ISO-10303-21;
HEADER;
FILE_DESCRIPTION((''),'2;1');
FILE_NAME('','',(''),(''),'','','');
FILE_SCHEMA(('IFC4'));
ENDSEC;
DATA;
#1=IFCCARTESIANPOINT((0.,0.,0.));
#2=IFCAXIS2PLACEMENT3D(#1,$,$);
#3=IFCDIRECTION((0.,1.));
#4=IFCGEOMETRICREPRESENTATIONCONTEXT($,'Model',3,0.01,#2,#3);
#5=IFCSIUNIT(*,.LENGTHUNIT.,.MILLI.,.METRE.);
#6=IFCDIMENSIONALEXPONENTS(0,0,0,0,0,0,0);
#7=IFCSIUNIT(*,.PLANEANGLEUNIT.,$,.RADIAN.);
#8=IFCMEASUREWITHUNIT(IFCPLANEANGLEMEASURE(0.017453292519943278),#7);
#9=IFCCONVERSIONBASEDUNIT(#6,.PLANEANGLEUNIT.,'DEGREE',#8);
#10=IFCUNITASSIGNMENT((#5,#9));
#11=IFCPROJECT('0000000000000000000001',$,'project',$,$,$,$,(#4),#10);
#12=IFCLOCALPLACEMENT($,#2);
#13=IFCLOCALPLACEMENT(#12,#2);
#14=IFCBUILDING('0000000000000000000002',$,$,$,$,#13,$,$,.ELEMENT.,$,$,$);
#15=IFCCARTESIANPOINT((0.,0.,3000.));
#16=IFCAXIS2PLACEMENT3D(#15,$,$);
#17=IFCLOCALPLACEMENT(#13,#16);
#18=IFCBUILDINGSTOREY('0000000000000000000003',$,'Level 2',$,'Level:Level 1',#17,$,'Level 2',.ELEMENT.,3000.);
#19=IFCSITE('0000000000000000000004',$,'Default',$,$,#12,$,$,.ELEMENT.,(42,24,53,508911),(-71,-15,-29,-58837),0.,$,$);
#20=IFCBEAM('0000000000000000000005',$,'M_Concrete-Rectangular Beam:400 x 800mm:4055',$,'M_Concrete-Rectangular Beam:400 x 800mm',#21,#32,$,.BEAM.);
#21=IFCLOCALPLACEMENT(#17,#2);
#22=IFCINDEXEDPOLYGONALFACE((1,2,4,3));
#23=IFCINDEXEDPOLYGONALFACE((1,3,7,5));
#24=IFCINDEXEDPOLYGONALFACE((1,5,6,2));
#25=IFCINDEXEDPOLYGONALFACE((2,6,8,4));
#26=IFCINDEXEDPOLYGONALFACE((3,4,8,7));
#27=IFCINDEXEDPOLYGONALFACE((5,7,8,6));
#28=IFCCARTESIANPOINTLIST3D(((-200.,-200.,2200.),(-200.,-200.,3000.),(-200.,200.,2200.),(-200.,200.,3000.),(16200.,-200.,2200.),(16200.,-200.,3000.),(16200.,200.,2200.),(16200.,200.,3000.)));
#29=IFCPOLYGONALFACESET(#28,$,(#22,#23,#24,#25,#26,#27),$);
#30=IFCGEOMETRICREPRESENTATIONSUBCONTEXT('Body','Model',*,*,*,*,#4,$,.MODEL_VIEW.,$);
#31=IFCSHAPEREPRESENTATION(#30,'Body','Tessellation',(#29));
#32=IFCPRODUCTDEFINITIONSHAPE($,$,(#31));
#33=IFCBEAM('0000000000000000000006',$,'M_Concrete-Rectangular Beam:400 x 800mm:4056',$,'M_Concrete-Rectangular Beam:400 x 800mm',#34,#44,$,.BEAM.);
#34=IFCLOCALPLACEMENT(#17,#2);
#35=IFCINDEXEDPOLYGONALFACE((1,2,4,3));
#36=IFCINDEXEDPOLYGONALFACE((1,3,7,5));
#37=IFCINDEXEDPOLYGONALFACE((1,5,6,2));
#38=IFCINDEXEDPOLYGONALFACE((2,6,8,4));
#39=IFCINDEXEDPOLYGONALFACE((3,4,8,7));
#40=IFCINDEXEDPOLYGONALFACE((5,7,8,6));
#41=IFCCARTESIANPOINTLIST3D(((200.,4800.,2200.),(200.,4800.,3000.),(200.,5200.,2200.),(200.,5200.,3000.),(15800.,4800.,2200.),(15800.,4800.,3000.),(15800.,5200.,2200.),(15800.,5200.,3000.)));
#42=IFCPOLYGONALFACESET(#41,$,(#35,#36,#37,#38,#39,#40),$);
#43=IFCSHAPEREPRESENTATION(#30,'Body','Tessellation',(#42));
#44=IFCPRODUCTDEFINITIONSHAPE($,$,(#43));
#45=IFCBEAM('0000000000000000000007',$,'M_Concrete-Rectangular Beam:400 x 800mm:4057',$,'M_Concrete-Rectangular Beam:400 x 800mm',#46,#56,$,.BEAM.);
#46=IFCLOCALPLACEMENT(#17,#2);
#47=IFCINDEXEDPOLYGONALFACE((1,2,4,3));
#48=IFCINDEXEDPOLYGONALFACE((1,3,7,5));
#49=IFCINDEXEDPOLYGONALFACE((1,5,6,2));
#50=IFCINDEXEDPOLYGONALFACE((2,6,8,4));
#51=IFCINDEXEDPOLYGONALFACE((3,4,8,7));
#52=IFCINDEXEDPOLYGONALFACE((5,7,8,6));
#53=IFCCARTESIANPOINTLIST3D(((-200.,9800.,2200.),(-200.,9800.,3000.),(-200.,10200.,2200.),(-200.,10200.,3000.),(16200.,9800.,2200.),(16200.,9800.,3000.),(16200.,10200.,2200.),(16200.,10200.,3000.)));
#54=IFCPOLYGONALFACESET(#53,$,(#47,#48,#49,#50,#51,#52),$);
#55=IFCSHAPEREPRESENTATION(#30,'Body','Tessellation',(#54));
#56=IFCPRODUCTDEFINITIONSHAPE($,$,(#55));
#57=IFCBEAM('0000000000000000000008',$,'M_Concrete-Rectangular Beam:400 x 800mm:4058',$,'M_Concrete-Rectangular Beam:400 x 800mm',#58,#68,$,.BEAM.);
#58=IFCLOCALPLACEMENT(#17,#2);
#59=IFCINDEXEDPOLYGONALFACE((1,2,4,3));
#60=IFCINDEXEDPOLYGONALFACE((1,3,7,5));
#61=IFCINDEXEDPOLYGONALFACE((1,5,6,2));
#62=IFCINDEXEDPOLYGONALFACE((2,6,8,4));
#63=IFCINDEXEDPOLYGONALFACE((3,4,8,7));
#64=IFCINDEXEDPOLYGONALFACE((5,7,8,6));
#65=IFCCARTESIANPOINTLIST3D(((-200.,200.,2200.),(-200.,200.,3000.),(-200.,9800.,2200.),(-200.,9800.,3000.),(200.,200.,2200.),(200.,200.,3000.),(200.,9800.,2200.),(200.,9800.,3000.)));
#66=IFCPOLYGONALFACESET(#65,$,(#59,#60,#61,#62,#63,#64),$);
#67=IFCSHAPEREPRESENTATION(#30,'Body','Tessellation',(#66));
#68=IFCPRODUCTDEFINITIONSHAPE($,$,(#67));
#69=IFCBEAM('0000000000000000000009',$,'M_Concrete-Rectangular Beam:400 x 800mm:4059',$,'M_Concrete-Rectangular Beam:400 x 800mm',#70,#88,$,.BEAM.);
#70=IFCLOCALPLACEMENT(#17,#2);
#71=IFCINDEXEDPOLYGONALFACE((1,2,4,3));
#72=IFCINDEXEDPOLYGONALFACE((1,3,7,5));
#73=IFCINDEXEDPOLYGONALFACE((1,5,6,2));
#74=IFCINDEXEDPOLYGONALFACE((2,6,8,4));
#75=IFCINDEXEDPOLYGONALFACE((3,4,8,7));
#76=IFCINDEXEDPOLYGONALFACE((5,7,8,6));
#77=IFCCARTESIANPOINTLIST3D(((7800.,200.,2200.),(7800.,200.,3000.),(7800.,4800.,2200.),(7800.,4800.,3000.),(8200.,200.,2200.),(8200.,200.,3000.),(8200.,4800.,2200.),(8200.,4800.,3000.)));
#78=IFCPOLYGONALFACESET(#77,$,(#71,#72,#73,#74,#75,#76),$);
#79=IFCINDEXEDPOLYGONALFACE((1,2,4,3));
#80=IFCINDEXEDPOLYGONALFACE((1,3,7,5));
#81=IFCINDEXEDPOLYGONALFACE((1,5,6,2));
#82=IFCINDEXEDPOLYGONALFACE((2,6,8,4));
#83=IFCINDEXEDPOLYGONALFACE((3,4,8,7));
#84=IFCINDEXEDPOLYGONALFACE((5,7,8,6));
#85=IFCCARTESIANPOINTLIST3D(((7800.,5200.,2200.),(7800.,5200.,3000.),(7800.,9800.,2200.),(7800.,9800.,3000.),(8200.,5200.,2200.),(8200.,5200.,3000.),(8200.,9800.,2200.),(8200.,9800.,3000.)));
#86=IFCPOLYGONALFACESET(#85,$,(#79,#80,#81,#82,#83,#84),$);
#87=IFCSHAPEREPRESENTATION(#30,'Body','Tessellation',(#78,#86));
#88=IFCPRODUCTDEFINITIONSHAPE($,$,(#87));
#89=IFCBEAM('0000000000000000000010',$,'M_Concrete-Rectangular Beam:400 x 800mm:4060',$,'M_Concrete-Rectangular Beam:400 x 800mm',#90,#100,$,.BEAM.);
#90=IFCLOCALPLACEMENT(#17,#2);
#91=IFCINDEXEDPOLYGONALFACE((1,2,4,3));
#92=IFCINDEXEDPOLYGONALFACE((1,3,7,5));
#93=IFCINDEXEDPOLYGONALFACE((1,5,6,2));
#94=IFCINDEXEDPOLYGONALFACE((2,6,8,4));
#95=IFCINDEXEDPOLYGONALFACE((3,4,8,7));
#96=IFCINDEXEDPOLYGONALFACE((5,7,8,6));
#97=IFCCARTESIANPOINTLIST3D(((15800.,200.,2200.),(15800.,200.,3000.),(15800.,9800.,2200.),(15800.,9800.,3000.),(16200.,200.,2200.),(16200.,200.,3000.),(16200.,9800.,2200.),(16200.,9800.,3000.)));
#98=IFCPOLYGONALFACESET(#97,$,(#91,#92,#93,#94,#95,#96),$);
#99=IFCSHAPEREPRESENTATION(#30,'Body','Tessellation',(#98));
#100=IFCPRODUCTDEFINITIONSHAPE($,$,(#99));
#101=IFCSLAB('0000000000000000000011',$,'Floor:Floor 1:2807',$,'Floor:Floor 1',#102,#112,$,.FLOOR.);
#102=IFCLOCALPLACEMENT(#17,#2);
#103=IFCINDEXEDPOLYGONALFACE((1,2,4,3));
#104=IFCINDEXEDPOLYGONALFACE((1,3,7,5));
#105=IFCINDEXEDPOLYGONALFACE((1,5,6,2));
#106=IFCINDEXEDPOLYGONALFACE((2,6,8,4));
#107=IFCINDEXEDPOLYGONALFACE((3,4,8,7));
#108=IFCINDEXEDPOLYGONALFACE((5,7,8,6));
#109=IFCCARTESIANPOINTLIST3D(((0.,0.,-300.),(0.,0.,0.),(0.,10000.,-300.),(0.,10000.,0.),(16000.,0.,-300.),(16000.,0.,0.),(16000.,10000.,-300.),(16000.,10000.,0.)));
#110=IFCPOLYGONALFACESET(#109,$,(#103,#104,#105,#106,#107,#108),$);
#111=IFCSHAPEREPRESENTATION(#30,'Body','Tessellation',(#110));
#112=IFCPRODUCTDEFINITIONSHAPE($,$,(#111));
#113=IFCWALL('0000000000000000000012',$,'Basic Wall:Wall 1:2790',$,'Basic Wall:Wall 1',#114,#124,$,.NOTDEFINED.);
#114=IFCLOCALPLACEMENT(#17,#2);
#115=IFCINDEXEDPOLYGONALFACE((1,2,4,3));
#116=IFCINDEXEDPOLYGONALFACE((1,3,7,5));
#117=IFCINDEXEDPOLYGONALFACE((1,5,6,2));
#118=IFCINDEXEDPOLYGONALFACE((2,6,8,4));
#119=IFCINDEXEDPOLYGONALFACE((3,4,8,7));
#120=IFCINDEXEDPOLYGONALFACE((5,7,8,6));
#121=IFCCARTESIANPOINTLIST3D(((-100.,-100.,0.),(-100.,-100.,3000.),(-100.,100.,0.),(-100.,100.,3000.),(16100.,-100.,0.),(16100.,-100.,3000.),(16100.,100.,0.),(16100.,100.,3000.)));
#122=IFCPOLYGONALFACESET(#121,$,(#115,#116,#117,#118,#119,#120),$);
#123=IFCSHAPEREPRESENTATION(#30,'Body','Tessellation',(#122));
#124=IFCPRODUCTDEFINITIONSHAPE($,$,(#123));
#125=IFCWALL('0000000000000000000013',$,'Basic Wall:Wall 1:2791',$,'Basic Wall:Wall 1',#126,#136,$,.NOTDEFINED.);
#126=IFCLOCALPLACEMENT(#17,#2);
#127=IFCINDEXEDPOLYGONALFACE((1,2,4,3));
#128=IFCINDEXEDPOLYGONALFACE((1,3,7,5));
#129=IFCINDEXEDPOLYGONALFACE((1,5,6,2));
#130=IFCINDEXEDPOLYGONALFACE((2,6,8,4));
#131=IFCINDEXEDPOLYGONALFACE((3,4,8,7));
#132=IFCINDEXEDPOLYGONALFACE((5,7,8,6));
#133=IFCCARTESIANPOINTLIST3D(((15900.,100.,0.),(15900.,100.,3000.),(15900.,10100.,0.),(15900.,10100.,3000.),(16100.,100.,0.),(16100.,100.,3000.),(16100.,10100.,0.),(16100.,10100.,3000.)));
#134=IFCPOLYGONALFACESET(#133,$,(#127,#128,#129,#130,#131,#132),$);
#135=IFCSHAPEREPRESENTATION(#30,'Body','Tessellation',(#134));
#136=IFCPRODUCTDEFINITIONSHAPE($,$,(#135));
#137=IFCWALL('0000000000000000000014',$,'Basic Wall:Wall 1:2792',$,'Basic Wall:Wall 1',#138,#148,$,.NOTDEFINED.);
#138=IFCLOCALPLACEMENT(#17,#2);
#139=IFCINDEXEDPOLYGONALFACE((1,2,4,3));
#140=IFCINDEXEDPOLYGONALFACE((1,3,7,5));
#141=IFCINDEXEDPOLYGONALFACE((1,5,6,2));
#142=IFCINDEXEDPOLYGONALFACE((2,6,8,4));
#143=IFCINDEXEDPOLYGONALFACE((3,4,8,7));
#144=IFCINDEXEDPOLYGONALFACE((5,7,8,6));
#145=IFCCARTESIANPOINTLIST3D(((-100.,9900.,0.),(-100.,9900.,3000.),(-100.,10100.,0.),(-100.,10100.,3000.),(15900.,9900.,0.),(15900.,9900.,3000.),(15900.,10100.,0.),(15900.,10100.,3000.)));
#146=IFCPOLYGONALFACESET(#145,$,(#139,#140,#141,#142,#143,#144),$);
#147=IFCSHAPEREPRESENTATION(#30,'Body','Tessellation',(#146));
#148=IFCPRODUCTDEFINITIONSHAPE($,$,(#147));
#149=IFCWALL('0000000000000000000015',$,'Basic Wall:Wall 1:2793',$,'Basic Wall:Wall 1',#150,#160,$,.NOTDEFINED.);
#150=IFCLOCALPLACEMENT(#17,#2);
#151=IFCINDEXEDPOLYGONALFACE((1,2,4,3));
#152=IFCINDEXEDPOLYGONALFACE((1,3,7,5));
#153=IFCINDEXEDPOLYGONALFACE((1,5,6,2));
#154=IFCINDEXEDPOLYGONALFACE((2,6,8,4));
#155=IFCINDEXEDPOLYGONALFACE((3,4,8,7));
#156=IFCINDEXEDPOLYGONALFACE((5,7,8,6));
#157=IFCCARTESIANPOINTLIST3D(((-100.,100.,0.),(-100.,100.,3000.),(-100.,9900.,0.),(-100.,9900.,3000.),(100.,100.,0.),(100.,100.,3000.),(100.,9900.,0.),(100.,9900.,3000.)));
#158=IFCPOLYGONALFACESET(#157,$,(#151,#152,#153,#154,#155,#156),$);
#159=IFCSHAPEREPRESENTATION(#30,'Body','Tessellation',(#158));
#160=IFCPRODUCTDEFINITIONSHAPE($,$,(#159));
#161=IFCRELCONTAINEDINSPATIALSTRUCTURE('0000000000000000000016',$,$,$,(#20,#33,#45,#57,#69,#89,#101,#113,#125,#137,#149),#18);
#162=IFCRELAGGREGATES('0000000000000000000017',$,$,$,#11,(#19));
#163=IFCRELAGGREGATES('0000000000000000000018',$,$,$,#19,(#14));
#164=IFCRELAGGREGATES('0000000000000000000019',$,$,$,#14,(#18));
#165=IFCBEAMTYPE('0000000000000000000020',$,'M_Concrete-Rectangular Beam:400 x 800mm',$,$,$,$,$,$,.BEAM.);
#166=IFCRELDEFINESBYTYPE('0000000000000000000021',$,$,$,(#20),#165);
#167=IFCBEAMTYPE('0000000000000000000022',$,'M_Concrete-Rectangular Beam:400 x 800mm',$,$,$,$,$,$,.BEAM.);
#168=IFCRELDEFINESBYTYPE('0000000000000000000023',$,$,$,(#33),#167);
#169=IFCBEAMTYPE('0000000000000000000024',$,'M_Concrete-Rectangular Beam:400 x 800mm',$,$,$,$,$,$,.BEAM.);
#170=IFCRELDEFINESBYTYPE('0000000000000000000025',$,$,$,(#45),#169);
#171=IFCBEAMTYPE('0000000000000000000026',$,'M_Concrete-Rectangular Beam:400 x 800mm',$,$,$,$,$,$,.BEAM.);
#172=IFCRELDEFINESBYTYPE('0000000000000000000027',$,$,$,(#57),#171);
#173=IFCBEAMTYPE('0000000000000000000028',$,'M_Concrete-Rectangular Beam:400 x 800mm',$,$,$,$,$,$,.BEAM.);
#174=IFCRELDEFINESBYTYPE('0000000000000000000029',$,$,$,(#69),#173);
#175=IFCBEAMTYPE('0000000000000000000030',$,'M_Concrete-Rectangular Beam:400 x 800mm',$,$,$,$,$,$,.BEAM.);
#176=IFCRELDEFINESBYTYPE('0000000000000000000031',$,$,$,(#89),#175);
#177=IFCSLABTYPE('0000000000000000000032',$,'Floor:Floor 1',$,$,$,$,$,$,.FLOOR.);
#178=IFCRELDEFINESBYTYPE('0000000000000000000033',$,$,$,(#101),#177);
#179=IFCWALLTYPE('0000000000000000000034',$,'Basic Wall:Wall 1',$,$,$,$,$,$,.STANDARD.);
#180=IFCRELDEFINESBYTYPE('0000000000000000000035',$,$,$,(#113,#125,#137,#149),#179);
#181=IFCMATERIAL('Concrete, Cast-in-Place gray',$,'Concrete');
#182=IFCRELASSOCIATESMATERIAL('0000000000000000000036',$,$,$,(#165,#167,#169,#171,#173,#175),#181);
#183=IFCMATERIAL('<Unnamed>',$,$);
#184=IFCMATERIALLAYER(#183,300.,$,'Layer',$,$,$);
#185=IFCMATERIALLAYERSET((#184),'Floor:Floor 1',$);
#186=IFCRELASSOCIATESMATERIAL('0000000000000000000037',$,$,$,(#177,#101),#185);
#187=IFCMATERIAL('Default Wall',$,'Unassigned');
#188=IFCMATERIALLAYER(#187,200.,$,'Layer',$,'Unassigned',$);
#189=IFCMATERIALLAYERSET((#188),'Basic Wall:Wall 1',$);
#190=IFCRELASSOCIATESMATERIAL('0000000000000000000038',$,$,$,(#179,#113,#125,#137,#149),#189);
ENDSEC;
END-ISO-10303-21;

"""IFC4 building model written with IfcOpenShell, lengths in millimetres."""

from ifc_helpers import new_model, entity, si_unit, converted_unit, direction, frame, frame_2d, origin, origin_2d_with_axis, place, context, subcontext, project, spatial, rectangle, extrude, source, transform, mapped, material, layer, layer_set, layer_usage, material_profile, profile_set, type_object, type_shapes, element, save


model = new_model("IFC4")

# Units and contexts
model_context = context("Model", 3, precision=0.01, world=origin(), true_north=direction((0.0, 1.0)))
body_context = subcontext(model_context, "Body", "Model", "MODEL_VIEW")
ifc_project = project(units=[si_unit("LENGTHUNIT", "METRE", prefix="MILLI"), converted_unit("PLANEANGLEUNIT", "DEGREE", entity("IfcPlaneAngleMeasure", 0.017453292519943278), si_unit("PLANEANGLEUNIT", "RADIAN"), dimensions=[0, 0, 0, 0, 0, 0, 0])], contexts=[model_context])

# Site, building, storey
site_placement = place(None, origin())
site = spatial("IfcSite", under=ifc_project, at=site_placement, Name="Default", CompositionType="ELEMENT", RefLatitude=(42, 24, 53, 508911), RefLongitude=(-71, -15, -29, -58837), RefElevation=0.0)
building_placement = place(site_placement, origin())
building = spatial("IfcBuilding", under=site, at=building_placement, CompositionType="ELEMENT")
storey_placement = place(building_placement, frame((0.0, 0.0, 3000.0)))
storey = spatial("IfcBuildingStorey", under=building, at=storey_placement, Name="Level 2", ObjectType="Level:Level 1", LongName="Level 2", CompositionType="ELEMENT", Elevation=3000.0)

# Beams
ifc_material_1 = material(Name="Concrete, Cast-in-Place gray", Category="Concrete")
ifc_material_profile = material_profile(ifc_material_1, rectangle(XDim=800.0, YDim=400.0, at=origin_2d_with_axis()), Name="400 x 800mm")
ifc_profile_set = profile_set([ifc_material_profile], Name="400 x 800mm")
beam_type_1 = type_object("IfcBeamType", Name="M_Concrete-Rectangular Beam:400 x 800mm", PredefinedType="BEAM", material=ifc_profile_set)
shared_shape_1 = source(origin(), body_context, "Body", "SweptSolid", [
    extrude(rectangle(XDim=800.0, YDim=400.0, at=origin_2d_with_axis()), frame((-200.0, 0.0, 5600.0), z_axis=(1.0, 0.0, 0.0), x_axis=(0.0, 0.0, -1.0)), (0.0, 0.0, 1.0), 16400.0),
])
type_shapes(beam_type_1, [shared_shape_1])
beam_1_placement = place(storey_placement, frame((0.0, 0.0, -3000.0)))
element("IfcBeam", 1, at=beam_1_placement, inside=storey, type_object=beam_type_1, Name="M_Concrete-Rectangular Beam:400 x 800mm:4055", ObjectType="M_Concrete-Rectangular Beam:400 x 800mm", PredefinedType="BEAM", context=body_context, shape_type="MappedRepresentation", body=[
    mapped(shared_shape_1, transform((0.0, 0.0, 0.0), scale=1.0)),
])
beam_type_2 = type_object("IfcBeamType", Name="M_Concrete-Rectangular Beam:400 x 800mm", PredefinedType="BEAM", material=ifc_profile_set)
shared_shape_2 = source(origin(), body_context, "Body", "SweptSolid", [
    extrude(rectangle(XDim=800.0, YDim=400.0, at=frame_2d((0.0, 0.0), x_axis=(1.0, 0.0))), frame((200.0, 5000.0, 5600.0), z_axis=(1.0, 0.0, 0.0), x_axis=(0.0, 0.0, -1.0)), (0.0, 0.0, 1.0), 15600.0),
])
type_shapes(beam_type_2, [shared_shape_2])
beam_2_placement = place(storey_placement, frame((0.0, 0.0, -3000.0)))
element("IfcBeam", 2, at=beam_2_placement, inside=storey, type_object=beam_type_2, Name="M_Concrete-Rectangular Beam:400 x 800mm:4056", ObjectType="M_Concrete-Rectangular Beam:400 x 800mm", PredefinedType="BEAM", context=body_context, shape_type="MappedRepresentation", body=[
    mapped(shared_shape_2, transform((0.0, 0.0, 0.0), scale=1.0)),
])
beam_type_3 = type_object("IfcBeamType", Name="M_Concrete-Rectangular Beam:400 x 800mm", PredefinedType="BEAM", material=ifc_profile_set)
shared_shape_3 = source(origin(), body_context, "Body", "SweptSolid", [
    extrude(rectangle(XDim=800.0, YDim=400.0, at=frame_2d((0.0, 0.0), x_axis=(1.0, 0.0))), frame((-200.0, 10000.0, 5600.0), z_axis=(1.0, 0.0, 0.0), x_axis=(0.0, 0.0, -1.0)), (0.0, 0.0, 1.0), 16400.0),
])
type_shapes(beam_type_3, [shared_shape_3])
beam_3_placement = place(storey_placement, frame((0.0, 0.0, -3000.0)))
element("IfcBeam", 3, at=beam_3_placement, inside=storey, type_object=beam_type_3, Name="M_Concrete-Rectangular Beam:400 x 800mm:4057", ObjectType="M_Concrete-Rectangular Beam:400 x 800mm", PredefinedType="BEAM", context=body_context, shape_type="MappedRepresentation", body=[
    mapped(shared_shape_3, transform((0.0, 0.0, 0.0), scale=1.0)),
])
beam_type_4 = type_object("IfcBeamType", Name="M_Concrete-Rectangular Beam:400 x 800mm", PredefinedType="BEAM", material=ifc_profile_set)
shared_shape_4 = source(origin(), body_context, "Body", "SweptSolid", [
    extrude(rectangle(XDim=800.0, YDim=400.0, at=frame_2d((0.0, 0.0), x_axis=(0.0, 1.0))), frame((0.0, 200.0, 5600.0), z_axis=(0.0, 1.0, 0.0), x_axis=(-1.0, 0.0, 0.0)), (0.0, 0.0, 1.0), 9600.0),
])
type_shapes(beam_type_4, [shared_shape_4])
beam_4_placement = place(storey_placement, frame((0.0, 0.0, -3000.0)))
element("IfcBeam", 4, at=beam_4_placement, inside=storey, type_object=beam_type_4, Name="M_Concrete-Rectangular Beam:400 x 800mm:4058", ObjectType="M_Concrete-Rectangular Beam:400 x 800mm", PredefinedType="BEAM", context=body_context, shape_type="MappedRepresentation", body=[
    mapped(shared_shape_4, transform((0.0, 0.0, 0.0), scale=1.0)),
])
beam_type_5 = type_object("IfcBeamType", Name="M_Concrete-Rectangular Beam:400 x 800mm", PredefinedType="BEAM", material=ifc_profile_set)
shared_shape_5 = source(origin(), body_context, "Body", "SweptSolid", [
    extrude(rectangle(XDim=800.0, YDim=400.0, at=frame_2d((0.0, 0.0), x_axis=(0.0, 1.0))), frame((8000.0, 200.0, 5600.0), z_axis=(0.0, 1.0, 0.0), x_axis=(-1.0, 0.0, 0.0)), (0.0, 0.0, 1.0), 4600.0),
    extrude(rectangle(XDim=800.0, YDim=400.0, at=frame_2d((0.0, 0.0), x_axis=(0.0, 1.0))), frame((8000.0, 5200.0, 5600.0), z_axis=(0.0, 1.0, 0.0), x_axis=(-1.0, 0.0, 0.0)), (0.0, 0.0, 1.0), 4600.0),
])
type_shapes(beam_type_5, [shared_shape_5])
beam_5_placement = place(storey_placement, frame((0.0, 0.0, -3000.0)))
element("IfcBeam", 5, at=beam_5_placement, inside=storey, type_object=beam_type_5, Name="M_Concrete-Rectangular Beam:400 x 800mm:4059", ObjectType="M_Concrete-Rectangular Beam:400 x 800mm", PredefinedType="BEAM", context=body_context, shape_type="MappedRepresentation", body=[
    mapped(shared_shape_5, transform((0.0, 0.0, 0.0), scale=1.0)),
])
beam_type_6 = type_object("IfcBeamType", Name="M_Concrete-Rectangular Beam:400 x 800mm", PredefinedType="BEAM", material=ifc_profile_set)
shared_shape_6 = source(origin(), body_context, "Body", "SweptSolid", [
    extrude(rectangle(XDim=800.0, YDim=400.0, at=frame_2d((0.0, 0.0), x_axis=(0.0, 1.0))), frame((16000.0, 200.0, 5600.0), z_axis=(0.0, 1.0, 0.0), x_axis=(-1.0, 0.0, 0.0)), (0.0, 0.0, 1.0), 9600.0),
])
type_shapes(beam_type_6, [shared_shape_6])
beam_6_placement = place(storey_placement, frame((0.0, 0.0, -3000.0)))
element("IfcBeam", 6, at=beam_6_placement, inside=storey, type_object=beam_type_6, Name="M_Concrete-Rectangular Beam:400 x 800mm:4060", ObjectType="M_Concrete-Rectangular Beam:400 x 800mm", PredefinedType="BEAM", context=body_context, shape_type="MappedRepresentation", body=[
    mapped(shared_shape_6, transform((0.0, 0.0, 0.0), scale=1.0)),
])

# Slab
ifc_material_2 = material(Name="<Unnamed>")
ifc_layer_1 = layer(ifc_material_2, 300.0, Name="Layer")
ifc_layer_set_1 = layer_set([ifc_layer_1], Name="Floor:Floor 1")
ifc_layer_usage_1 = layer_usage(ifc_layer_set_1, "AXIS3", "POSITIVE", 0.0)
slab_type = type_object("IfcSlabType", Name="Floor:Floor 1", PredefinedType="FLOOR", material=ifc_layer_set_1)
slab_placement = place(storey_placement, origin())
element("IfcSlab", 7, at=slab_placement, inside=storey, type_object=slab_type, material=ifc_layer_usage_1, Name="Floor:Floor 1:2807", ObjectType="Floor:Floor 1", PredefinedType="FLOOR", context=body_context, shape_type="SweptSolid", body=[
    extrude(rectangle(XDim=10000.0, YDim=16000.0, at=origin_2d_with_axis()), frame((8000.0, 5000.0, 0.0), z_axis=(0.0, 0.0, -1.0), x_axis=(0.0, 1.0, 0.0)), (0.0, 0.0, 1.0), 300.0),
])

# Walls
ifc_material_3 = material(Name="Default Wall", Category="Unassigned")
ifc_layer_2 = layer(ifc_material_3, 200.0, Name="Layer", Category="Unassigned")
ifc_layer_set_2 = layer_set([ifc_layer_2], Name="Basic Wall:Wall 1")
ifc_layer_usage_2 = layer_usage(ifc_layer_set_2, "AXIS2", "NEGATIVE", 100.0)
wall_type = type_object("IfcWallType", Name="Basic Wall:Wall 1", PredefinedType="STANDARD", material=ifc_layer_set_2)
wall_1_placement = place(storey_placement, frame((-100.0, 0.0, 0.0)))
element("IfcWall", 8, at=wall_1_placement, inside=storey, type_object=wall_type, material=ifc_layer_usage_2, Name="Basic Wall:Wall 1:2790", ObjectType="Basic Wall:Wall 1", PredefinedType="NOTDEFINED", context=body_context, shape_type="SweptSolid", body=[
    extrude(rectangle(XDim=16200.0, YDim=200.0, at=frame_2d((8100.0, 0.0), x_axis=(-1.0, 0.0))), origin(), (0.0, 0.0, 1.0), 3000.0),
])
ifc_layer_usage_3 = layer_usage(ifc_layer_set_2, "AXIS2", "NEGATIVE", 100.0)
wall_2_placement = place(storey_placement, frame((16000.0, 100.0, 0.0), z_axis=(0.0, 0.0, 1.0), x_axis=(0.0, 1.0, 0.0)))
element("IfcWall", 9, at=wall_2_placement, inside=storey, type_object=wall_type, material=ifc_layer_usage_3, Name="Basic Wall:Wall 1:2791", ObjectType="Basic Wall:Wall 1", PredefinedType="NOTDEFINED", context=body_context, shape_type="SweptSolid", body=[
    extrude(rectangle(XDim=10000.0, YDim=200.0, at=frame_2d((5000.0, 0.0), x_axis=(-1.0, 0.0))), origin(), (0.0, 0.0, 1.0), 3000.0),
])
ifc_layer_usage_4 = layer_usage(ifc_layer_set_2, "AXIS2", "NEGATIVE", 100.0)
wall_3_placement = place(storey_placement, frame((15900.0, 10000.0, 0.0), z_axis=(0.0, 0.0, 1.0), x_axis=(-1.0, 0.0, 0.0)))
element("IfcWall", 10, at=wall_3_placement, inside=storey, type_object=wall_type, material=ifc_layer_usage_4, Name="Basic Wall:Wall 1:2792", ObjectType="Basic Wall:Wall 1", PredefinedType="NOTDEFINED", context=body_context, shape_type="SweptSolid", body=[
    extrude(rectangle(XDim=16000.0, YDim=200.0, at=frame_2d((8000.0, 0.0), x_axis=(-1.0, 0.0))), origin(), (0.0, 0.0, 1.0), 3000.0),
])
ifc_layer_usage_5 = layer_usage(ifc_layer_set_2, "AXIS2", "NEGATIVE", 100.0)
wall_4_placement = place(storey_placement, frame((0.0, 9900.0, 0.0), z_axis=(0.0, 0.0, 1.0), x_axis=(0.0, -1.0, 0.0)))
element("IfcWall", 11, at=wall_4_placement, inside=storey, type_object=wall_type, material=ifc_layer_usage_5, Name="Basic Wall:Wall 1:2793", ObjectType="Basic Wall:Wall 1", PredefinedType="NOTDEFINED", context=body_context, shape_type="SweptSolid", body=[
    extrude(rectangle(XDim=9800.0, YDim=200.0, at=frame_2d((4900.0, 0.0), x_axis=(-1.0, 0.0))), origin(), (0.0, 0.0, 1.0), 3000.0),
])

save(model, "model.ifc")
